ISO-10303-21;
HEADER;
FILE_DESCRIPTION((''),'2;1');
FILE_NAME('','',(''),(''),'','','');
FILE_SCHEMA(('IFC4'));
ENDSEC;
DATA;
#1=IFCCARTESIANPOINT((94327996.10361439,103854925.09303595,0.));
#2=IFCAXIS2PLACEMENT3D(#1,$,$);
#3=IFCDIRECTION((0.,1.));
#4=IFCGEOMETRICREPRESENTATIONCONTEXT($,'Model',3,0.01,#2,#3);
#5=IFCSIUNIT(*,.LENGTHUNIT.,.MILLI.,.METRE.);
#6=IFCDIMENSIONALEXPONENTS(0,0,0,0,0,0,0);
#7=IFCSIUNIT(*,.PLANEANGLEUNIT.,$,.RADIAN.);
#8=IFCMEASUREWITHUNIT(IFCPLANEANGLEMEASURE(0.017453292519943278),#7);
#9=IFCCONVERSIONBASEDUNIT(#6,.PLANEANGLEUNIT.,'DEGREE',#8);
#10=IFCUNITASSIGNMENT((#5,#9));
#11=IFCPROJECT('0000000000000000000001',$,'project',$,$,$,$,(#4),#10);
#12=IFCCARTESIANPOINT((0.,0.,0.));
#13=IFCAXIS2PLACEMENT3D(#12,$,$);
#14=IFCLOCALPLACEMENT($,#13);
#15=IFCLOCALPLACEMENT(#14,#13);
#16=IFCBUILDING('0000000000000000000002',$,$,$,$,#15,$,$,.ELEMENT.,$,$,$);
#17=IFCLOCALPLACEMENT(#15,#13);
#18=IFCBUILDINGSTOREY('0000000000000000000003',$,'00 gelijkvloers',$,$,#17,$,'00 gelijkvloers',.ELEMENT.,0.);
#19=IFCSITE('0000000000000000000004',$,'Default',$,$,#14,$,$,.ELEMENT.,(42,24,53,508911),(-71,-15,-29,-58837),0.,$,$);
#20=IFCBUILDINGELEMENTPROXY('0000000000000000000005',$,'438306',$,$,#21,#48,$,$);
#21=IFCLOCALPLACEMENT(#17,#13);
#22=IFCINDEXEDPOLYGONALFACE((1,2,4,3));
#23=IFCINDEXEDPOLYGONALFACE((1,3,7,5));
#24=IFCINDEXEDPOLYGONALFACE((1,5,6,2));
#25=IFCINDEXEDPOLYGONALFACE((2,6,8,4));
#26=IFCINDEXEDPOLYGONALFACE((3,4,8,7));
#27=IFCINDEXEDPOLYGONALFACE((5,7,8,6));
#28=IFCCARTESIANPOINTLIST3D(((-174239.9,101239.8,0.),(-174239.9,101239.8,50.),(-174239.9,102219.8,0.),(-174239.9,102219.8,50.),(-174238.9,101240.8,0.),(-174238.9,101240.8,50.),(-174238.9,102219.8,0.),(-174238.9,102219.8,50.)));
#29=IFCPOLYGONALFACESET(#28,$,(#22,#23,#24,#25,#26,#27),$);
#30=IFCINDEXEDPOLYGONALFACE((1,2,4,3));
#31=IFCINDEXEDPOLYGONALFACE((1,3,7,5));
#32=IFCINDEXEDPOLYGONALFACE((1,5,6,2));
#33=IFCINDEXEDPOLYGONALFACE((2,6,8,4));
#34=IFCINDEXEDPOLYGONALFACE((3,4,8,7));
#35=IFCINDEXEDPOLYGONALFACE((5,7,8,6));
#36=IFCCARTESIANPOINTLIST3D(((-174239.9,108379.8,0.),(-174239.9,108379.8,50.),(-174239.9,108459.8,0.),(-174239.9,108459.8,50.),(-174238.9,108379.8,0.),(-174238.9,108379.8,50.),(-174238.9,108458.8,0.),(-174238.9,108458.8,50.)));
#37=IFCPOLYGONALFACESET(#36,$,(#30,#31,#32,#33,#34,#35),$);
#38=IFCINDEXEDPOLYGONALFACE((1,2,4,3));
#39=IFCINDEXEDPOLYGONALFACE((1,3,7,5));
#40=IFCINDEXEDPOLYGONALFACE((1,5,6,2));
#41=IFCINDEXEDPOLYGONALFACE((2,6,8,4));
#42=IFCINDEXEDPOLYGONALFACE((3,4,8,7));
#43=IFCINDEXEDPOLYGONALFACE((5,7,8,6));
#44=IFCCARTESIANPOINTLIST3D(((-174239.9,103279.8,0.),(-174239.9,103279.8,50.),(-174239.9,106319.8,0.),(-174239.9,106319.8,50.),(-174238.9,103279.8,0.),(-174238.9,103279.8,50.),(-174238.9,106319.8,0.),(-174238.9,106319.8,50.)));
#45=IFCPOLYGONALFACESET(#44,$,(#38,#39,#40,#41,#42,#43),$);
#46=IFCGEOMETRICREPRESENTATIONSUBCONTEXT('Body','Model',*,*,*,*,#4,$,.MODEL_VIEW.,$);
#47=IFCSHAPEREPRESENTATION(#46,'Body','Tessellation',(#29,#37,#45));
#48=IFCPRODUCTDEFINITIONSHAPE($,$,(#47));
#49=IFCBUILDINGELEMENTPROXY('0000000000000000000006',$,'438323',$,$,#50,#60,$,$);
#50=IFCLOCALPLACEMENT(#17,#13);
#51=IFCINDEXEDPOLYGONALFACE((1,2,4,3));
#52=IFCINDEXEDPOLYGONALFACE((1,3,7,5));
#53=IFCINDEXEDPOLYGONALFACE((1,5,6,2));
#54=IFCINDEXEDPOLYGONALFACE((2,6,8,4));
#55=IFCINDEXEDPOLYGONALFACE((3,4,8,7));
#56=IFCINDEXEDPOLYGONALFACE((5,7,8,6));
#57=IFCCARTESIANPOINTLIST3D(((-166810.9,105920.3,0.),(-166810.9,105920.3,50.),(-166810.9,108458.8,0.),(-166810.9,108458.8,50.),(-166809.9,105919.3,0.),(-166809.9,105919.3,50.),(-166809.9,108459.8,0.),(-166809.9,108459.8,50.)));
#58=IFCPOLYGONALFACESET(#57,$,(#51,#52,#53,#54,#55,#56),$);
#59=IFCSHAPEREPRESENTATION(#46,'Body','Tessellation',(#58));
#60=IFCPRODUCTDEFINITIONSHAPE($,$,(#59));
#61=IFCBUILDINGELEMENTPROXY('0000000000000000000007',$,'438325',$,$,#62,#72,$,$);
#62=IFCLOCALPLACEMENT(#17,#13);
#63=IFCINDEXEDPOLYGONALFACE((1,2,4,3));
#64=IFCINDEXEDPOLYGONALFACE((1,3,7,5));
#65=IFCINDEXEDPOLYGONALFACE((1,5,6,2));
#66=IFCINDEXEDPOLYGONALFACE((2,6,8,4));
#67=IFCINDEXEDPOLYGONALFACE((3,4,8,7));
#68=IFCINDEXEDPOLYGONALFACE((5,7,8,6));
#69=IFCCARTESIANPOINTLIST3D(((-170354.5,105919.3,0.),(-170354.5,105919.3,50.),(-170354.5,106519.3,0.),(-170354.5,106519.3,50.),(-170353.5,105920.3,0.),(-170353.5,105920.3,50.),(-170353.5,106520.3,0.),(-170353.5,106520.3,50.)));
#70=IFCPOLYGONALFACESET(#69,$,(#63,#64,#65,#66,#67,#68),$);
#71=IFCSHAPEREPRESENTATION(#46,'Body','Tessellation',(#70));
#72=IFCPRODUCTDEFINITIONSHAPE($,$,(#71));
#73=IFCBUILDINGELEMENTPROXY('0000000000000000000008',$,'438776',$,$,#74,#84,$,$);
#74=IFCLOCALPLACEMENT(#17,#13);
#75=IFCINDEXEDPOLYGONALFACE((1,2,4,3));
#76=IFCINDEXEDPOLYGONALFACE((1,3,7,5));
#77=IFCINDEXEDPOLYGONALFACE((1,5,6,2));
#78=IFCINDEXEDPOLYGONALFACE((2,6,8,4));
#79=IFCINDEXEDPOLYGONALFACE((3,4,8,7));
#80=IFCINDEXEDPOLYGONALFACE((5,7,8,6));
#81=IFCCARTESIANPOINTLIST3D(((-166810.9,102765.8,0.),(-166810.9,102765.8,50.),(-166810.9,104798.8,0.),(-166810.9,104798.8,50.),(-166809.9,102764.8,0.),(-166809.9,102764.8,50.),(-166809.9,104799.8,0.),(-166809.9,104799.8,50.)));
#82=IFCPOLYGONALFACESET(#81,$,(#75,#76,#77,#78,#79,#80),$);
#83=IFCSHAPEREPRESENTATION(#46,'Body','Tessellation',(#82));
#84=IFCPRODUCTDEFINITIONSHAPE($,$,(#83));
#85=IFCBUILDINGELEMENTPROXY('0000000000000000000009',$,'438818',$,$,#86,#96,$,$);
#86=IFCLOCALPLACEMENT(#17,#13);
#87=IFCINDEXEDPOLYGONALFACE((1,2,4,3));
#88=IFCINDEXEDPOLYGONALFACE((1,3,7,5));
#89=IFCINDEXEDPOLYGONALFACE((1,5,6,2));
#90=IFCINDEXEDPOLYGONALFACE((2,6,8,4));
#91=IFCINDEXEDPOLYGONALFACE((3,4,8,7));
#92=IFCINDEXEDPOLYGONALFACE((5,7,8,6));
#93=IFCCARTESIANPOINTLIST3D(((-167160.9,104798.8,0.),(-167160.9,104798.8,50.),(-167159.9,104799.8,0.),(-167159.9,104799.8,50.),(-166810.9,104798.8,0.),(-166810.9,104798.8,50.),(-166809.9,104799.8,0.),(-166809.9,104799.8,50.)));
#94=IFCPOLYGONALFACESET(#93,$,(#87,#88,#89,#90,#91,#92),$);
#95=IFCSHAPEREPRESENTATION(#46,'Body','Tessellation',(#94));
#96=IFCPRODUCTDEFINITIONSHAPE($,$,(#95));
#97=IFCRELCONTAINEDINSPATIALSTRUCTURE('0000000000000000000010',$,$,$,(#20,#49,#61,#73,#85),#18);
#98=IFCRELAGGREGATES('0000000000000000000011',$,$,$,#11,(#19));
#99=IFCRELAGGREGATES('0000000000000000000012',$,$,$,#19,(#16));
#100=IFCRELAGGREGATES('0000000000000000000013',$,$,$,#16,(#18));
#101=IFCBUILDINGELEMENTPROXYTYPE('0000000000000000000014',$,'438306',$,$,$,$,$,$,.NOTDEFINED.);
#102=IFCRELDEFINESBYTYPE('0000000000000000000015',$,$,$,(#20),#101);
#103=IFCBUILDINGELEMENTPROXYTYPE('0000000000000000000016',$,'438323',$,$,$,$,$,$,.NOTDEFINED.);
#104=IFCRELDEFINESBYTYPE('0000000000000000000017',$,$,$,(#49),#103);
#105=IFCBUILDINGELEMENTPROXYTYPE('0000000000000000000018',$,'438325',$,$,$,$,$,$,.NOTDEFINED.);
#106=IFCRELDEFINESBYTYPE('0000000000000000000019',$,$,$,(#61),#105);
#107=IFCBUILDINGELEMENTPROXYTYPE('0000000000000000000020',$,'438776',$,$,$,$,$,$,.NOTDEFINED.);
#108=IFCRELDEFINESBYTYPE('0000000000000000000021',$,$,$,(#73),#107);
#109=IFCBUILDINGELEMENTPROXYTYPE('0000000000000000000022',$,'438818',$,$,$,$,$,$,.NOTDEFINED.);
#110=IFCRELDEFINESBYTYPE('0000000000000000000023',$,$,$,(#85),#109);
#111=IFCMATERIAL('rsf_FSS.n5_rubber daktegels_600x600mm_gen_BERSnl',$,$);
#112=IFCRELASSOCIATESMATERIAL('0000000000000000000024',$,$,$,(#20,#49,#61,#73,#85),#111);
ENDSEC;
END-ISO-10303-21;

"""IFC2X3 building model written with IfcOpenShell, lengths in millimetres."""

from ifc_helpers import new_model, entity, si_unit, converted_unit, direction, frame, frame_2d, origin, place, context, subcontext, project, spatial, polyline, rectangle, outline, extrude, material, type_object, element, save


model = new_model("IFC2X3")

# Units and contexts
model_context = context("Model", 3, precision=0.01, world=frame((94327996.10361439, 103854925.09303595, 0.0)), true_north=direction((0.0, 1.0)))
body_context = subcontext(model_context, "Body", "Model", "MODEL_VIEW")
ifc_project = project(units=[si_unit("LENGTHUNIT", "METRE", prefix="MILLI"), converted_unit("PLANEANGLEUNIT", "DEGREE", entity("IfcPlaneAngleMeasure", 0.017453292519943278), si_unit("PLANEANGLEUNIT", "RADIAN"), dimensions=[0, 0, 0, 0, 0, 0, 0])], contexts=[model_context])

# Site, building, storey
site_placement = place(None, origin())
site = spatial("IfcSite", under=ifc_project, at=site_placement, Name="Default", CompositionType="ELEMENT", RefLatitude=(42, 24, 53, 508911), RefLongitude=(-71, -15, -29, -58837), RefElevation=0.0)
building_placement = place(site_placement, origin())
building = spatial("IfcBuilding", under=site, at=building_placement, CompositionType="ELEMENT")
storey_placement = place(building_placement, origin())
storey = spatial("IfcBuildingStorey", under=building, at=storey_placement, Name="00 gelijkvloers", LongName="00 gelijkvloers", CompositionType="ELEMENT", Elevation=0.0)

# Building element proxies
ifc_material_1 = material(Name="rsf_FSS.n5_rubber daktegels_600x600mm_gen_BERSnl")
building_element_proxy_type_1 = type_object("IfcBuildingElementProxyType", Name="438306", PredefinedType="NOTDEFINED")
proxy_1_placement = place(storey_placement, origin())
element("IfcBuildingElementProxy", 1, at=proxy_1_placement, inside=storey, type_object=building_element_proxy_type_1, material=ifc_material_1, Name="438306", context=body_context, shape_type="SweptSolid", body=[
    extrude(outline(polyline([(-489.2, -0.5), (489.7, -0.5), (489.7, 0.5), (-490.2, 0.5), (-489.2, -0.5)])), frame((-174239.4, 101730.0, 0.0), z_axis=(0.0, 0.0, 1.0), x_axis=(0.0, 1.0, 0.0)), (0.0, 0.0, 1.0), 50.0),
    extrude(outline(polyline([(-39.8, -0.5), (39.3, -0.5), (40.3, 0.5), (-39.8, 0.5), (-39.8, -0.5)])), frame((-174239.4, 108419.5, 0.0), z_axis=(0.0, 0.0, 1.0), x_axis=(0.0, 1.0, 0.0)), (0.0, 0.0, 1.0), 50.0),
    extrude(rectangle(XDim=3040.0, YDim=1.0, at=frame_2d((0.0, 0.0), x_axis=(1.0, 0.0))), frame((-174239.4, 104799.8, 0.0), z_axis=(0.0, 0.0, 1.0), x_axis=(0.0, 1.0, 0.0)), (0.0, 0.0, 1.0), 50.0),
])
building_element_proxy_type_2 = type_object("IfcBuildingElementProxyType", Name="438323", PredefinedType="NOTDEFINED")
proxy_2_placement = place(storey_placement, origin())
element("IfcBuildingElementProxy", 2, at=proxy_2_placement, inside=storey, type_object=building_element_proxy_type_2, material=ifc_material_1, Name="438323", context=body_context, shape_type="SweptSolid", body=[
    extrude(outline(polyline([(-1269.2, -0.5), (1269.2, -0.5), (1270.2, 0.5), (-1270.2, 0.5), (-1269.2, -0.5)])), frame((-166810.4, 107189.5, 0.0), z_axis=(0.0, 0.0, 1.0), x_axis=(0.0, -1.0, 0.0)), (0.0, 0.0, 1.0), 50.0),
])
building_element_proxy_type_3 = type_object("IfcBuildingElementProxyType", Name="438325", PredefinedType="NOTDEFINED")
proxy_3_placement = place(storey_placement, origin())
element("IfcBuildingElementProxy", 3, at=proxy_3_placement, inside=storey, type_object=building_element_proxy_type_3, material=ifc_material_1, Name="438325", context=body_context, shape_type="SweptSolid", body=[
    extrude(outline(polyline([(-299.5, -0.5), (300.5, -0.5), (299.5, 0.5), (-300.5, 0.5), (-299.5, -0.5)])), frame((-170354.0, 106219.8, 0.0), z_axis=(0.0, 0.0, 1.0), x_axis=(0.0, 1.0, 0.0)), (0.0, 0.0, 1.0), 50.0),
])
building_element_proxy_type_4 = type_object("IfcBuildingElementProxyType", Name="438776", PredefinedType="NOTDEFINED")
proxy_4_placement = place(storey_placement, origin())
element("IfcBuildingElementProxy", 4, at=proxy_4_placement, inside=storey, type_object=building_element_proxy_type_4, material=ifc_material_1, Name="438776", context=body_context, shape_type="SweptSolid", body=[
    extrude(outline(polyline([(-1017.5, -0.5), (1017.5, -0.5), (1016.5, 0.5), (-1016.5, 0.5), (-1017.5, -0.5)])), frame((-166810.4, 103782.3, 0.0), z_axis=(0.0, 0.0, 1.0), x_axis=(0.0, 1.0, 0.0)), (0.0, 0.0, 1.0), 50.0),
])
building_element_proxy_type_5 = type_object("IfcBuildingElementProxyType", Name="438818", PredefinedType="NOTDEFINED")
proxy_5_placement = place(storey_placement, origin())
element("IfcBuildingElementProxy", 5, at=proxy_5_placement, inside=storey, type_object=building_element_proxy_type_5, material=ifc_material_1, Name="438818", context=body_context, shape_type="SweptSolid", body=[
    extrude(outline(polyline([(-175.5, -0.5), (174.5, -0.5), (175.5, 0.5), (-174.5, 0.5), (-175.5, -0.5)])), frame((-166985.4, 104799.3, 0.0), z_axis=(0.0, 0.0, 1.0), x_axis=(-1.0, 0.0, 0.0)), (0.0, 0.0, 1.0), 50.0),
])

save(model, "model.ifc")
